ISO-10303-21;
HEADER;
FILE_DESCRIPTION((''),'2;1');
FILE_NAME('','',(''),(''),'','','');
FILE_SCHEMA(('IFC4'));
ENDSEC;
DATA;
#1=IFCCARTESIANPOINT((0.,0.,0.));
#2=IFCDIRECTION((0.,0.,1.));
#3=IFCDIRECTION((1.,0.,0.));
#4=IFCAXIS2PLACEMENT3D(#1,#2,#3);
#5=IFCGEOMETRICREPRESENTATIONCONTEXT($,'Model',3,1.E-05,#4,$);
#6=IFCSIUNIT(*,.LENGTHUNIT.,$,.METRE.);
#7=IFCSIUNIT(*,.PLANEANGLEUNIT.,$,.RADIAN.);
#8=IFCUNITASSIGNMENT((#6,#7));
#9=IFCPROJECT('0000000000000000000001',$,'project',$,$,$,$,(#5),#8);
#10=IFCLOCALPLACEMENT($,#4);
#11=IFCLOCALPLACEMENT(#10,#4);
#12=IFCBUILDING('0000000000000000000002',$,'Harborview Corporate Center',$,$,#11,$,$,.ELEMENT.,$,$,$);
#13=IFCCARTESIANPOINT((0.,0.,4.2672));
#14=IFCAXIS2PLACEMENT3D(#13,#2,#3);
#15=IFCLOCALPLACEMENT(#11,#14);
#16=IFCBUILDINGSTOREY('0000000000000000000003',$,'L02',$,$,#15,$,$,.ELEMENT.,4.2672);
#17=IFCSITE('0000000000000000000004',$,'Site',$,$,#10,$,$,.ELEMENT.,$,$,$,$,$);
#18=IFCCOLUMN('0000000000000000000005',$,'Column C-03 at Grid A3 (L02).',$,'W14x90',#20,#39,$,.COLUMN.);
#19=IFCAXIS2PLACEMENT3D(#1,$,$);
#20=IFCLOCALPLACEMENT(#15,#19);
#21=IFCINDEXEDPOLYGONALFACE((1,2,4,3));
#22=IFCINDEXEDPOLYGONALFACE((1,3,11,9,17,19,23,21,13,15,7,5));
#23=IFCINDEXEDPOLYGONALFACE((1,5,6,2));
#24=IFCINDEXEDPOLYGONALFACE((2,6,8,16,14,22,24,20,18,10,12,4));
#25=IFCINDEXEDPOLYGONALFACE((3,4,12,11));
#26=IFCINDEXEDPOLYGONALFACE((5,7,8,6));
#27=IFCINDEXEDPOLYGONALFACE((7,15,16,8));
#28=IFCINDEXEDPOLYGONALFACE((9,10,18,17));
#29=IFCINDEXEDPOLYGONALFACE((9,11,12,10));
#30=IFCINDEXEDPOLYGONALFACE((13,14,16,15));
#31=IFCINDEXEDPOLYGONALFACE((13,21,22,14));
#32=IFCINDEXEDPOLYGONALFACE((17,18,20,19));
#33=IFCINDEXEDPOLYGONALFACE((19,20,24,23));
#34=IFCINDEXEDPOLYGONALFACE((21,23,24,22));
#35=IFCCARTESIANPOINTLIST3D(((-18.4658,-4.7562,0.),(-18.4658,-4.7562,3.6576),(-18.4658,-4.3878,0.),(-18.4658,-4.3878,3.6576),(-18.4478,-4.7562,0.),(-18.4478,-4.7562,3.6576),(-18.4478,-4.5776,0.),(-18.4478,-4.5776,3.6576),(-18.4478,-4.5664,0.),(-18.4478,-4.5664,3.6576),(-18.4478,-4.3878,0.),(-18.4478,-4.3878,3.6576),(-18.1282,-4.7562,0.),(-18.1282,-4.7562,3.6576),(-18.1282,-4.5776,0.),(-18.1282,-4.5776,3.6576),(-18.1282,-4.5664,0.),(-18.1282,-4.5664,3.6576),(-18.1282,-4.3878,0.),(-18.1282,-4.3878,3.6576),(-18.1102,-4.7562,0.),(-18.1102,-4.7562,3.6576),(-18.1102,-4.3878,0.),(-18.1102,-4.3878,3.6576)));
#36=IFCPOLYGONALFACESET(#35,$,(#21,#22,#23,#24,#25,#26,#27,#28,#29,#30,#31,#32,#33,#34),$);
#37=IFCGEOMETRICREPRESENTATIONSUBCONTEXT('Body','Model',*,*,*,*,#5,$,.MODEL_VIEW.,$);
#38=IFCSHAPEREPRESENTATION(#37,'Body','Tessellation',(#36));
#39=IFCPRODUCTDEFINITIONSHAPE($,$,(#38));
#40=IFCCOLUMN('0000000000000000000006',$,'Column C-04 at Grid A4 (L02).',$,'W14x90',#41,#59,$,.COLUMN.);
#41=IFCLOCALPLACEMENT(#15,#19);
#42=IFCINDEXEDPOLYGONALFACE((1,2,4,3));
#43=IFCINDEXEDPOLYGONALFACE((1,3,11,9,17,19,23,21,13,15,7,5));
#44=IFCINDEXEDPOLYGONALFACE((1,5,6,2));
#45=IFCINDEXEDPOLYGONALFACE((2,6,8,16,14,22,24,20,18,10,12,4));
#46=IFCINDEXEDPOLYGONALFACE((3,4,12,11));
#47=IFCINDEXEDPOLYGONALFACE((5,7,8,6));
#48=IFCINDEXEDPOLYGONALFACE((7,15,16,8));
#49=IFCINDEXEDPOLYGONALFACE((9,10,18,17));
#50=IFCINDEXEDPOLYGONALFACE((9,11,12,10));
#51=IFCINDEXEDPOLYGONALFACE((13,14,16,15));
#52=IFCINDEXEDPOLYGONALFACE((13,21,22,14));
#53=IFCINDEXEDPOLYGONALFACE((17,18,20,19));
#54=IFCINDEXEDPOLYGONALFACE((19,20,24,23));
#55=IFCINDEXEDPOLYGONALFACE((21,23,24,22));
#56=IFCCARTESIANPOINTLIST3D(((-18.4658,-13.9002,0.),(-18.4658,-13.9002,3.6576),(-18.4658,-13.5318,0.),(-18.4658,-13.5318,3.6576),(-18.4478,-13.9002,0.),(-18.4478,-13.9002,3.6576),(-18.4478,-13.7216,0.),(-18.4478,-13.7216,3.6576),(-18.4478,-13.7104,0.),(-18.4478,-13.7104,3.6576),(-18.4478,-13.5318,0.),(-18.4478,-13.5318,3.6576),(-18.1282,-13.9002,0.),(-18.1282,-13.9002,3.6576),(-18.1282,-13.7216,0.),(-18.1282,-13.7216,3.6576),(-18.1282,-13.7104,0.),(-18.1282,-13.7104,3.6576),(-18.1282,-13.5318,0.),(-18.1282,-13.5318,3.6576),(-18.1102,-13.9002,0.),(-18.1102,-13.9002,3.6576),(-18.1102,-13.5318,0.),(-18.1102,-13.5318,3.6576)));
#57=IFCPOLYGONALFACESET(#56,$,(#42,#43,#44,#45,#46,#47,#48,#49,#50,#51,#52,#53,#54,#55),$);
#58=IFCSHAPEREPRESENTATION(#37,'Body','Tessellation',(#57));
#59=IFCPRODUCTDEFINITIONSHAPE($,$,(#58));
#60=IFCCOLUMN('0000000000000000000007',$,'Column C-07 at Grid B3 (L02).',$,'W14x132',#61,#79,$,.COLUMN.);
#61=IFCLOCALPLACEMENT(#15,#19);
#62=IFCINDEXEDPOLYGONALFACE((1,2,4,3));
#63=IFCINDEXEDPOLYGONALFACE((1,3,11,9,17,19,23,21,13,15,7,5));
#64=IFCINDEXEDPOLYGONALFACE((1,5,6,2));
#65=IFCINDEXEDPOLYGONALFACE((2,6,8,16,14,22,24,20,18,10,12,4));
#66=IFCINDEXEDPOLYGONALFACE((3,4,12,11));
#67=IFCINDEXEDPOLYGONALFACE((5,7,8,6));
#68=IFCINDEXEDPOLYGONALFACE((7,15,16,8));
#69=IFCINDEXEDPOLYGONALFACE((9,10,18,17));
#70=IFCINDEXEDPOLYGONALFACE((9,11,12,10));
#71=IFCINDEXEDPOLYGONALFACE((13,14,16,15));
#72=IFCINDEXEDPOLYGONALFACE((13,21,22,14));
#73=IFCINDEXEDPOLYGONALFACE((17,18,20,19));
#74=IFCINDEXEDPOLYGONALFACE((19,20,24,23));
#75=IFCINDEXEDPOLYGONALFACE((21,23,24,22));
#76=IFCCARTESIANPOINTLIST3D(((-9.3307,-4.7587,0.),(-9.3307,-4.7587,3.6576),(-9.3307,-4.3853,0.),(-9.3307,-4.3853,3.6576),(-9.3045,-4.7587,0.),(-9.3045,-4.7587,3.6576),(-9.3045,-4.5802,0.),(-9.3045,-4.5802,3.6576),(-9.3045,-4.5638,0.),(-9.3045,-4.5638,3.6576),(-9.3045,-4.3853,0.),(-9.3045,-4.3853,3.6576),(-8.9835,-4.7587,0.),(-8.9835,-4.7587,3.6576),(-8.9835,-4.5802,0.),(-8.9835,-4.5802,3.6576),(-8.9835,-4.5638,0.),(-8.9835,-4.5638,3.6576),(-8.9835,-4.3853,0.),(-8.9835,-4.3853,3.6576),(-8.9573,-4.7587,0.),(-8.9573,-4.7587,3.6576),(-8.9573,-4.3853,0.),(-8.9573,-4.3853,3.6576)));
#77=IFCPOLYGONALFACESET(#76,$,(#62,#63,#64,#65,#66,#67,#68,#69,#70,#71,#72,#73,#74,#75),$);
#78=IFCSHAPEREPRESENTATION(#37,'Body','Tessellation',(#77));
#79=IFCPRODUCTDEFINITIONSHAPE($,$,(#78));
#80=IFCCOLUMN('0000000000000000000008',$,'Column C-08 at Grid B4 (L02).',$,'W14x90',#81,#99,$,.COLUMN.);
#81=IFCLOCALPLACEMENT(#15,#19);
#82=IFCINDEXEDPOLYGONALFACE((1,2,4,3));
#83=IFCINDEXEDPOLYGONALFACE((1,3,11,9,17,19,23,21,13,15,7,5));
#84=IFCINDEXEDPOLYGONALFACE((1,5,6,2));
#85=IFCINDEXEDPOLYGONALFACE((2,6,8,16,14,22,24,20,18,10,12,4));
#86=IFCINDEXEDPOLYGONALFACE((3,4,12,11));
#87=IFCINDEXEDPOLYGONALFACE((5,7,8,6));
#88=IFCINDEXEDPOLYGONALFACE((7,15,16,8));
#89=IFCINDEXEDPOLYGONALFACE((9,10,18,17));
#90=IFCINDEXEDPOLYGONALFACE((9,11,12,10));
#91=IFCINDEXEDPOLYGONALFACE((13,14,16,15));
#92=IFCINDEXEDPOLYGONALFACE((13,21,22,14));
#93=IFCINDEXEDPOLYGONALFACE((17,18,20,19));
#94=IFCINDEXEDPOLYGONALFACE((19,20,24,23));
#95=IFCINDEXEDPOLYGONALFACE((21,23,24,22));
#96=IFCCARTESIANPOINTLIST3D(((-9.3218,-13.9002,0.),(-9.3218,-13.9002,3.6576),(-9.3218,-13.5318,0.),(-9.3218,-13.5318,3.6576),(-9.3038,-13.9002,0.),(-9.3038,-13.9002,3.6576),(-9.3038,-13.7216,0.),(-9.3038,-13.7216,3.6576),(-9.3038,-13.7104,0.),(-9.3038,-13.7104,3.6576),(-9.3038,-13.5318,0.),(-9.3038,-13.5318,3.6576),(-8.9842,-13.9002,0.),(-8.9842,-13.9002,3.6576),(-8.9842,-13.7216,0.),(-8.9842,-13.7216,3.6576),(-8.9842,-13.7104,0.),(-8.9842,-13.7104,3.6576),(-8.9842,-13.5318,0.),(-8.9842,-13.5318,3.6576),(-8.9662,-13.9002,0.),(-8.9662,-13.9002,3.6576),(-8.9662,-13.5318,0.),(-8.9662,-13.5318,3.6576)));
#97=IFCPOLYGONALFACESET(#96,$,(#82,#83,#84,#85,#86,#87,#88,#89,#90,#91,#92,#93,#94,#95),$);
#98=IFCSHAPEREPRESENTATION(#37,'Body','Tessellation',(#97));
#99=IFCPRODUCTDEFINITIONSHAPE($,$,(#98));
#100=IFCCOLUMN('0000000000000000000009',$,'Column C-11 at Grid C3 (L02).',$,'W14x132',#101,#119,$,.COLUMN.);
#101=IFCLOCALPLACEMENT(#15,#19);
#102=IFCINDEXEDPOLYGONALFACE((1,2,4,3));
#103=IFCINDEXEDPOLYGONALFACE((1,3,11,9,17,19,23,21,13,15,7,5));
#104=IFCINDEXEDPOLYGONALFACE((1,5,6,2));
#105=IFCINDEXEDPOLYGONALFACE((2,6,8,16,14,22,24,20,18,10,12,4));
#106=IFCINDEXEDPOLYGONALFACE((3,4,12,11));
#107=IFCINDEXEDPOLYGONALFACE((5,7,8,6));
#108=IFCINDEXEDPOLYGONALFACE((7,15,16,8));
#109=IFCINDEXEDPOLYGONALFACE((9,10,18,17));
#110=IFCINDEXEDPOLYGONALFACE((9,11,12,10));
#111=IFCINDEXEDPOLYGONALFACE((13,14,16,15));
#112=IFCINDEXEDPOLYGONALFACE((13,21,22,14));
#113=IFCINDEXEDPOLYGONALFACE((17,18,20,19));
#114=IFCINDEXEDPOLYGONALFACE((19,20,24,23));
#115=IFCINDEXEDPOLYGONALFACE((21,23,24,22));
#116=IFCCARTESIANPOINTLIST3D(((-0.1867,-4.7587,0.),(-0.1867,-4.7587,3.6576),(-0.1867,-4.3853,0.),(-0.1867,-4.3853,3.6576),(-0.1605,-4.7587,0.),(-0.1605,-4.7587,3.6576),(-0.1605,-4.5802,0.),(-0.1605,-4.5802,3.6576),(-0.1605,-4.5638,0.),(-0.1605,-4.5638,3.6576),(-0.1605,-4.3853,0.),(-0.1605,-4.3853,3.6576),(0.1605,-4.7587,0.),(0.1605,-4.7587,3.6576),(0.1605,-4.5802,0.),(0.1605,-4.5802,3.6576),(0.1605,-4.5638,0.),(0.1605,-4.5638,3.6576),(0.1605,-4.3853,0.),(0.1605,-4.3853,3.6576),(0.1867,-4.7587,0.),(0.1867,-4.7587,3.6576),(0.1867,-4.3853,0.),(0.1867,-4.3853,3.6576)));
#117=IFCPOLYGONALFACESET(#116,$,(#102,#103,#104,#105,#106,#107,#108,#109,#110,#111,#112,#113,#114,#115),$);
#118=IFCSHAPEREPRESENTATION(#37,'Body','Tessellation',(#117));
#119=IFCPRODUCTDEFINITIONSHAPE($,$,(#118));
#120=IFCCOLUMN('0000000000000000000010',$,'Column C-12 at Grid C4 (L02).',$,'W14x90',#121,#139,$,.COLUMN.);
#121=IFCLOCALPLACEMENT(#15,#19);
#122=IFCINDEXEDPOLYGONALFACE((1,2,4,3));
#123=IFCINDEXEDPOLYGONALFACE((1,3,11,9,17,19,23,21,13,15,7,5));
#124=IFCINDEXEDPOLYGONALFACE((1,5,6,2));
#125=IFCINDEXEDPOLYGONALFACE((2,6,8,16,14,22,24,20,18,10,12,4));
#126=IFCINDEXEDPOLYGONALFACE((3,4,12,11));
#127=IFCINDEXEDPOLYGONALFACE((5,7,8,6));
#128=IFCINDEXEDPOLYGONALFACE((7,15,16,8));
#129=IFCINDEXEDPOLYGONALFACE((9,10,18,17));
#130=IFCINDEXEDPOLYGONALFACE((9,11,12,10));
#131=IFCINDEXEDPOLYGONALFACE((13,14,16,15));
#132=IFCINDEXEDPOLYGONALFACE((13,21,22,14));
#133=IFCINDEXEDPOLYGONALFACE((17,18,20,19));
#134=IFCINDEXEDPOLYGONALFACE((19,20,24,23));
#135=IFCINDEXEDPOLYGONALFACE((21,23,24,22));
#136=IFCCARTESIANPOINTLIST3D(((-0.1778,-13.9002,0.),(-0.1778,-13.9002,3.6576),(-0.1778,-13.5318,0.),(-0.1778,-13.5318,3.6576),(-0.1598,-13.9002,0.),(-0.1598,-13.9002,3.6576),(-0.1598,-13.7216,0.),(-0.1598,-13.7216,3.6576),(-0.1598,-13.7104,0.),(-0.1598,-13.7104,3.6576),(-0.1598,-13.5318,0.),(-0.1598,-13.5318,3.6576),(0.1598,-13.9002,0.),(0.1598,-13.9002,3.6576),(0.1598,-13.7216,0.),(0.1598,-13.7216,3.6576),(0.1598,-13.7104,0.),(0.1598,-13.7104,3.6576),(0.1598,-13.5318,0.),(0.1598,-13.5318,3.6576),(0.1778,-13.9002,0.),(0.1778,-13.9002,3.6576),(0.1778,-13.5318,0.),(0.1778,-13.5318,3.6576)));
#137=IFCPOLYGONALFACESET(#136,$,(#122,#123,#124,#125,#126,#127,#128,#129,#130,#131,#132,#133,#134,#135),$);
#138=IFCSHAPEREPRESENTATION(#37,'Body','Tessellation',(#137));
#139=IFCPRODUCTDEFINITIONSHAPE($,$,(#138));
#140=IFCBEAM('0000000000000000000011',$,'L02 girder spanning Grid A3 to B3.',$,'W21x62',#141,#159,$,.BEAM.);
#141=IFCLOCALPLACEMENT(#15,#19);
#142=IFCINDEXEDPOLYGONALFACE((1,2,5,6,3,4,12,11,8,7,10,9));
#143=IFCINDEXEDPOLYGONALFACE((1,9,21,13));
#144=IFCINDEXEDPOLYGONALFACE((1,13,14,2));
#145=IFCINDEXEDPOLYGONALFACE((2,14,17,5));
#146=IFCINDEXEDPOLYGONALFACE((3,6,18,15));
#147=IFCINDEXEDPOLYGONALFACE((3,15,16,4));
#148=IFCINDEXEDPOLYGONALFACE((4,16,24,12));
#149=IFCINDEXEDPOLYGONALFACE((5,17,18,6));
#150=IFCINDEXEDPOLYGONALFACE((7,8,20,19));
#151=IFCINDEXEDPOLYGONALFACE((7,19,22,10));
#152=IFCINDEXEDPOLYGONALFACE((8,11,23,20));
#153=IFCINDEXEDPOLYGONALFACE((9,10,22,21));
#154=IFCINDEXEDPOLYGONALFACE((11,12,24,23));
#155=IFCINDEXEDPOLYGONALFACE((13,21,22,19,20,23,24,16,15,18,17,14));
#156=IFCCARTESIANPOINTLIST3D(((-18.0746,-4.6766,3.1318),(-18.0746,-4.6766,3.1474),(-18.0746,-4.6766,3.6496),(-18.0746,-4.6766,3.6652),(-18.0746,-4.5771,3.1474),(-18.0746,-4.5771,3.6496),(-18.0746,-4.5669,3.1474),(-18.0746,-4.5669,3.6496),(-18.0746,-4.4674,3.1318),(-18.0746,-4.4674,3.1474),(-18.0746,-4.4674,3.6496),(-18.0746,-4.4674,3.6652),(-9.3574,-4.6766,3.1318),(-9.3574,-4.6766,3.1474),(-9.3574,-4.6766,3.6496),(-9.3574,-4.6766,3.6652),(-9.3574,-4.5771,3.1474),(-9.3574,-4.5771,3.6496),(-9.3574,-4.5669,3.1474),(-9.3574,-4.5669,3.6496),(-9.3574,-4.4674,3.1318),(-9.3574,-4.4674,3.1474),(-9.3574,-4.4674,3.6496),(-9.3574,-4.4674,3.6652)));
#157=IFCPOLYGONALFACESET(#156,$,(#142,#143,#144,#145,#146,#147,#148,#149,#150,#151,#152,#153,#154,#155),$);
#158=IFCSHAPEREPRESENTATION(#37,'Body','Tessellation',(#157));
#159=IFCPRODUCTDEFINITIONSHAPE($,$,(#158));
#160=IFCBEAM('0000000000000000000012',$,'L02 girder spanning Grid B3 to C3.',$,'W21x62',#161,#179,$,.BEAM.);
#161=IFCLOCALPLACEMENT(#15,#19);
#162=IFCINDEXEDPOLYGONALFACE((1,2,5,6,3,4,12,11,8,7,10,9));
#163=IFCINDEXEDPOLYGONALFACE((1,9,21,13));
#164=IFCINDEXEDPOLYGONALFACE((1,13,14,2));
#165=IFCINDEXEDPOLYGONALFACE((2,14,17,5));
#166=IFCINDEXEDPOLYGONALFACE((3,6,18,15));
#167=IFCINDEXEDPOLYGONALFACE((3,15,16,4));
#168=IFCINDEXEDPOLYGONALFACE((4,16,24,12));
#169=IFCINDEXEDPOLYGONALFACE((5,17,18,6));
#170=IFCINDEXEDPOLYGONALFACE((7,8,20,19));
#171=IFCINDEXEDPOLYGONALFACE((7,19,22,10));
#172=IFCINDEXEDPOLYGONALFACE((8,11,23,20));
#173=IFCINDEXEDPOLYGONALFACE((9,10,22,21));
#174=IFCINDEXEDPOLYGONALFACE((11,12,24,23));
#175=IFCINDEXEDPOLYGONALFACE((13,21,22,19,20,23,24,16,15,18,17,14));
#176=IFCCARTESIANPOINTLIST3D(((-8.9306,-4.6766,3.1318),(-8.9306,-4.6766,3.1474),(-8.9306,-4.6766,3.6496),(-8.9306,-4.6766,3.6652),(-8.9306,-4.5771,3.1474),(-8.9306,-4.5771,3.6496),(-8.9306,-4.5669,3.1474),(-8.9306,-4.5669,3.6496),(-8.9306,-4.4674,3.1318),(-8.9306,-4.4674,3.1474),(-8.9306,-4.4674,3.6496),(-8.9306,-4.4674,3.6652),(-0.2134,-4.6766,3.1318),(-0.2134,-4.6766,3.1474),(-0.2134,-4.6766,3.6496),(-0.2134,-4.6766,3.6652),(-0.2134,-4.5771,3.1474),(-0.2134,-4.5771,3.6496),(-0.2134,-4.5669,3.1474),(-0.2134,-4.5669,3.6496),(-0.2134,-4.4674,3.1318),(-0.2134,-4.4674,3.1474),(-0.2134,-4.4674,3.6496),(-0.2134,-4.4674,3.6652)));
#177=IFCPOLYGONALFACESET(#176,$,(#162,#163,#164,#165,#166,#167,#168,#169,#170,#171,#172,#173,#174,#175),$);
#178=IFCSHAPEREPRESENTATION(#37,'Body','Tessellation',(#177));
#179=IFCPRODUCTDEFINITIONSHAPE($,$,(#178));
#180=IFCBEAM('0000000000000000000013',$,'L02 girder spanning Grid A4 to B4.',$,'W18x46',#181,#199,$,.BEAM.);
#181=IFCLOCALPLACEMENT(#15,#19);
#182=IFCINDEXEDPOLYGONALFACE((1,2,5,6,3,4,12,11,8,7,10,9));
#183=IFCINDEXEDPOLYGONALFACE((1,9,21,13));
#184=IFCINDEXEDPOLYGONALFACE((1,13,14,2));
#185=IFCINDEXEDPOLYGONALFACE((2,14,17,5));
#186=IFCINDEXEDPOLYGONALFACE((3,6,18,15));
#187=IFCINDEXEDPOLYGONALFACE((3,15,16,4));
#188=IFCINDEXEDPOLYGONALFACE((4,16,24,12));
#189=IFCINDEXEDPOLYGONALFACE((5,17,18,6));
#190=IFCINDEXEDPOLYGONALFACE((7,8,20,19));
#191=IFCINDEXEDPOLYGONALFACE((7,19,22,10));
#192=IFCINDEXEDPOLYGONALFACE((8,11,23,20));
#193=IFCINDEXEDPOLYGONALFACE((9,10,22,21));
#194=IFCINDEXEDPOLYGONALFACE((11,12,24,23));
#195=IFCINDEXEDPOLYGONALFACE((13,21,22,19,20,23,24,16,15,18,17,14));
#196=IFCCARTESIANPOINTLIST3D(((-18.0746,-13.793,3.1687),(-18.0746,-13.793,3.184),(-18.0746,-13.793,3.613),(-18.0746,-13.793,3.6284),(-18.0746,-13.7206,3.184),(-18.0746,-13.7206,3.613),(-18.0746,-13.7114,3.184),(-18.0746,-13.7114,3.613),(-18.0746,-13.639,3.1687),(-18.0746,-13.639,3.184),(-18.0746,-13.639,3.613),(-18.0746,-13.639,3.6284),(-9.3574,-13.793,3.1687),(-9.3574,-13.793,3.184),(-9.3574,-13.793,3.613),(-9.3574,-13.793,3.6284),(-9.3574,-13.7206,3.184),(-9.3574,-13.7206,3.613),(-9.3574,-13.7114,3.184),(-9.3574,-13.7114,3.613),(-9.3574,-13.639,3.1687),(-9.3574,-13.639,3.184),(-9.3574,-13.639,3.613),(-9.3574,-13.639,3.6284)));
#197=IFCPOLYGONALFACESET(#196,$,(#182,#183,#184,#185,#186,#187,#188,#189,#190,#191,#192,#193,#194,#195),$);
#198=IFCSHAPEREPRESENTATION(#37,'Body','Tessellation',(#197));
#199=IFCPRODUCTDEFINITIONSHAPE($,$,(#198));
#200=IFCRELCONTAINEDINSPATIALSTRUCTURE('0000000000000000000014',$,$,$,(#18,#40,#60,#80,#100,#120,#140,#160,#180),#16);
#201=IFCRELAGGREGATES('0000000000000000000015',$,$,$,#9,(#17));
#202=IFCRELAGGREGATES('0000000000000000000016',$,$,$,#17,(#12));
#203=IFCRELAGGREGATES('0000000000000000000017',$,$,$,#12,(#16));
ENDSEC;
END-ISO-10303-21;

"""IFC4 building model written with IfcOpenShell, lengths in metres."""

from ifc_helpers import new_model, si_unit, frame, origin_with_axes, place, context, subcontext, project, spatial, i_section, extrude, element, save


model = new_model("IFC4")

# Units and contexts
model_context = context("Model", 3, precision=1e-05, world=origin_with_axes())
body_context = subcontext(model_context, "Body", "Model", "MODEL_VIEW")
ifc_project = project(units=[si_unit("LENGTHUNIT", "METRE"), si_unit("PLANEANGLEUNIT", "RADIAN")], contexts=[model_context])

# Site, building, storey
site_placement = place(None, origin_with_axes())
site = spatial("IfcSite", under=ifc_project, at=site_placement, Name="Site", CompositionType="ELEMENT")
building_placement = place(site_placement, origin_with_axes())
building = spatial("IfcBuilding", under=site, at=building_placement, Name="Harborview Corporate Center", CompositionType="ELEMENT")
storey_placement = place(building_placement, frame((0.0, 0.0, 4.2672), z_axis=(0.0, 0.0, 1.0), x_axis=(1.0, 0.0, 0.0)))
storey = spatial("IfcBuildingStorey", under=building, at=storey_placement, Name="L02", CompositionType="ELEMENT", Elevation=4.2672)

# Columns
for number, where, z_axis, x_axis, name in (
    (1, (-18.288, -4.572, 0.0), (0.0, 0.0, 1.0), (0.0, 1.0, 0.0), "Column C-03 at Grid A3 (L02)."),
    (2, (-18.288, -13.716, 0.0), (0.0, 0.0, 1.0), (0.0, 1.0, 0.0), "Column C-04 at Grid A4 (L02)."),
):
    element("IfcColumn", number, at=place(storey_placement, frame(where, z_axis=z_axis, x_axis=x_axis)), inside=storey, Name=name, ObjectType="W14x90", PredefinedType="COLUMN", context=body_context, shape_type="SweptSolid", body=[
        extrude(i_section(OverallWidth=0.3683, OverallDepth=0.3556, WebThickness=0.0112, FlangeThickness=0.018), origin_with_axes(), (0.0, 0.0, 1.0), 3.6576),
    ])
column_1_placement = place(storey_placement, frame((-9.144, -4.572, 0.0), z_axis=(0.0, 0.0, 1.0), x_axis=(0.0, 1.0, 0.0)))
element("IfcColumn", 3, at=column_1_placement, inside=storey, Name="Column C-07 at Grid B3 (L02).", ObjectType="W14x132", PredefinedType="COLUMN", context=body_context, shape_type="SweptSolid", body=[
    extrude(i_section(OverallWidth=0.3734, OverallDepth=0.3734, WebThickness=0.0164, FlangeThickness=0.0262), origin_with_axes(), (0.0, 0.0, 1.0), 3.6576),
])
column_2_placement = place(storey_placement, frame((-9.144, -13.716, 0.0), z_axis=(0.0, 0.0, 1.0), x_axis=(0.0, 1.0, 0.0)))
element("IfcColumn", 4, at=column_2_placement, inside=storey, Name="Column C-08 at Grid B4 (L02).", ObjectType="W14x90", PredefinedType="COLUMN", context=body_context, shape_type="SweptSolid", body=[
    extrude(i_section(OverallWidth=0.3683, OverallDepth=0.3556, WebThickness=0.0112, FlangeThickness=0.018), origin_with_axes(), (0.0, 0.0, 1.0), 3.6576),
])
column_3_placement = place(storey_placement, frame((0.0, -4.572, 0.0), z_axis=(0.0, 0.0, 1.0), x_axis=(0.0, 1.0, 0.0)))
element("IfcColumn", 5, at=column_3_placement, inside=storey, Name="Column C-11 at Grid C3 (L02).", ObjectType="W14x132", PredefinedType="COLUMN", context=body_context, shape_type="SweptSolid", body=[
    extrude(i_section(OverallWidth=0.3734, OverallDepth=0.3734, WebThickness=0.0164, FlangeThickness=0.0262), origin_with_axes(), (0.0, 0.0, 1.0), 3.6576),
])
column_4_placement = place(storey_placement, frame((0.0, -13.716, 0.0), z_axis=(0.0, 0.0, 1.0), x_axis=(0.0, 1.0, 0.0)))
element("IfcColumn", 6, at=column_4_placement, inside=storey, Name="Column C-12 at Grid C4 (L02).", ObjectType="W14x90", PredefinedType="COLUMN", context=body_context, shape_type="SweptSolid", body=[
    extrude(i_section(OverallWidth=0.3683, OverallDepth=0.3556, WebThickness=0.0112, FlangeThickness=0.018), origin_with_axes(), (0.0, 0.0, 1.0), 3.6576),
])

# Beams
beam_1_placement = place(storey_placement, frame((-18.0746, -4.572, 3.3985), z_axis=(1.0, 0.0, 0.0), x_axis=(0.0, 1.0, 0.0)))
element("IfcBeam", 7, at=beam_1_placement, inside=storey, Name="L02 girder spanning Grid A3 to B3.", ObjectType="W21x62", PredefinedType="BEAM", context=body_context, shape_type="SweptSolid", body=[
    extrude(i_section(OverallWidth=0.2093, OverallDepth=0.5334, WebThickness=0.0102, FlangeThickness=0.0156), origin_with_axes(), (0.0, 0.0, 1.0), 8.7173),
])
beam_2_placement = place(storey_placement, frame((-8.9306, -4.572, 3.3985), z_axis=(1.0, 0.0, 0.0), x_axis=(0.0, 1.0, 0.0)))
element("IfcBeam", 8, at=beam_2_placement, inside=storey, Name="L02 girder spanning Grid B3 to C3.", ObjectType="W21x62", PredefinedType="BEAM", context=body_context, shape_type="SweptSolid", body=[
    extrude(i_section(OverallWidth=0.2093, OverallDepth=0.5334, WebThickness=0.0102, FlangeThickness=0.0156), origin_with_axes(), (0.0, 0.0, 1.0), 8.7173),
])
beam_3_placement = place(storey_placement, frame((-18.0746, -13.716, 3.3985), z_axis=(1.0, 0.0, 0.0), x_axis=(0.0, 1.0, 0.0)))
element("IfcBeam", 9, at=beam_3_placement, inside=storey, Name="L02 girder spanning Grid A4 to B4.", ObjectType="W18x46", PredefinedType="BEAM", context=body_context, shape_type="SweptSolid", body=[
    extrude(i_section(OverallWidth=0.1539, OverallDepth=0.4597, WebThickness=0.0091, FlangeThickness=0.0154), origin_with_axes(), (0.0, 0.0, 1.0), 8.7173),
])

save(model, "model.ifc")
